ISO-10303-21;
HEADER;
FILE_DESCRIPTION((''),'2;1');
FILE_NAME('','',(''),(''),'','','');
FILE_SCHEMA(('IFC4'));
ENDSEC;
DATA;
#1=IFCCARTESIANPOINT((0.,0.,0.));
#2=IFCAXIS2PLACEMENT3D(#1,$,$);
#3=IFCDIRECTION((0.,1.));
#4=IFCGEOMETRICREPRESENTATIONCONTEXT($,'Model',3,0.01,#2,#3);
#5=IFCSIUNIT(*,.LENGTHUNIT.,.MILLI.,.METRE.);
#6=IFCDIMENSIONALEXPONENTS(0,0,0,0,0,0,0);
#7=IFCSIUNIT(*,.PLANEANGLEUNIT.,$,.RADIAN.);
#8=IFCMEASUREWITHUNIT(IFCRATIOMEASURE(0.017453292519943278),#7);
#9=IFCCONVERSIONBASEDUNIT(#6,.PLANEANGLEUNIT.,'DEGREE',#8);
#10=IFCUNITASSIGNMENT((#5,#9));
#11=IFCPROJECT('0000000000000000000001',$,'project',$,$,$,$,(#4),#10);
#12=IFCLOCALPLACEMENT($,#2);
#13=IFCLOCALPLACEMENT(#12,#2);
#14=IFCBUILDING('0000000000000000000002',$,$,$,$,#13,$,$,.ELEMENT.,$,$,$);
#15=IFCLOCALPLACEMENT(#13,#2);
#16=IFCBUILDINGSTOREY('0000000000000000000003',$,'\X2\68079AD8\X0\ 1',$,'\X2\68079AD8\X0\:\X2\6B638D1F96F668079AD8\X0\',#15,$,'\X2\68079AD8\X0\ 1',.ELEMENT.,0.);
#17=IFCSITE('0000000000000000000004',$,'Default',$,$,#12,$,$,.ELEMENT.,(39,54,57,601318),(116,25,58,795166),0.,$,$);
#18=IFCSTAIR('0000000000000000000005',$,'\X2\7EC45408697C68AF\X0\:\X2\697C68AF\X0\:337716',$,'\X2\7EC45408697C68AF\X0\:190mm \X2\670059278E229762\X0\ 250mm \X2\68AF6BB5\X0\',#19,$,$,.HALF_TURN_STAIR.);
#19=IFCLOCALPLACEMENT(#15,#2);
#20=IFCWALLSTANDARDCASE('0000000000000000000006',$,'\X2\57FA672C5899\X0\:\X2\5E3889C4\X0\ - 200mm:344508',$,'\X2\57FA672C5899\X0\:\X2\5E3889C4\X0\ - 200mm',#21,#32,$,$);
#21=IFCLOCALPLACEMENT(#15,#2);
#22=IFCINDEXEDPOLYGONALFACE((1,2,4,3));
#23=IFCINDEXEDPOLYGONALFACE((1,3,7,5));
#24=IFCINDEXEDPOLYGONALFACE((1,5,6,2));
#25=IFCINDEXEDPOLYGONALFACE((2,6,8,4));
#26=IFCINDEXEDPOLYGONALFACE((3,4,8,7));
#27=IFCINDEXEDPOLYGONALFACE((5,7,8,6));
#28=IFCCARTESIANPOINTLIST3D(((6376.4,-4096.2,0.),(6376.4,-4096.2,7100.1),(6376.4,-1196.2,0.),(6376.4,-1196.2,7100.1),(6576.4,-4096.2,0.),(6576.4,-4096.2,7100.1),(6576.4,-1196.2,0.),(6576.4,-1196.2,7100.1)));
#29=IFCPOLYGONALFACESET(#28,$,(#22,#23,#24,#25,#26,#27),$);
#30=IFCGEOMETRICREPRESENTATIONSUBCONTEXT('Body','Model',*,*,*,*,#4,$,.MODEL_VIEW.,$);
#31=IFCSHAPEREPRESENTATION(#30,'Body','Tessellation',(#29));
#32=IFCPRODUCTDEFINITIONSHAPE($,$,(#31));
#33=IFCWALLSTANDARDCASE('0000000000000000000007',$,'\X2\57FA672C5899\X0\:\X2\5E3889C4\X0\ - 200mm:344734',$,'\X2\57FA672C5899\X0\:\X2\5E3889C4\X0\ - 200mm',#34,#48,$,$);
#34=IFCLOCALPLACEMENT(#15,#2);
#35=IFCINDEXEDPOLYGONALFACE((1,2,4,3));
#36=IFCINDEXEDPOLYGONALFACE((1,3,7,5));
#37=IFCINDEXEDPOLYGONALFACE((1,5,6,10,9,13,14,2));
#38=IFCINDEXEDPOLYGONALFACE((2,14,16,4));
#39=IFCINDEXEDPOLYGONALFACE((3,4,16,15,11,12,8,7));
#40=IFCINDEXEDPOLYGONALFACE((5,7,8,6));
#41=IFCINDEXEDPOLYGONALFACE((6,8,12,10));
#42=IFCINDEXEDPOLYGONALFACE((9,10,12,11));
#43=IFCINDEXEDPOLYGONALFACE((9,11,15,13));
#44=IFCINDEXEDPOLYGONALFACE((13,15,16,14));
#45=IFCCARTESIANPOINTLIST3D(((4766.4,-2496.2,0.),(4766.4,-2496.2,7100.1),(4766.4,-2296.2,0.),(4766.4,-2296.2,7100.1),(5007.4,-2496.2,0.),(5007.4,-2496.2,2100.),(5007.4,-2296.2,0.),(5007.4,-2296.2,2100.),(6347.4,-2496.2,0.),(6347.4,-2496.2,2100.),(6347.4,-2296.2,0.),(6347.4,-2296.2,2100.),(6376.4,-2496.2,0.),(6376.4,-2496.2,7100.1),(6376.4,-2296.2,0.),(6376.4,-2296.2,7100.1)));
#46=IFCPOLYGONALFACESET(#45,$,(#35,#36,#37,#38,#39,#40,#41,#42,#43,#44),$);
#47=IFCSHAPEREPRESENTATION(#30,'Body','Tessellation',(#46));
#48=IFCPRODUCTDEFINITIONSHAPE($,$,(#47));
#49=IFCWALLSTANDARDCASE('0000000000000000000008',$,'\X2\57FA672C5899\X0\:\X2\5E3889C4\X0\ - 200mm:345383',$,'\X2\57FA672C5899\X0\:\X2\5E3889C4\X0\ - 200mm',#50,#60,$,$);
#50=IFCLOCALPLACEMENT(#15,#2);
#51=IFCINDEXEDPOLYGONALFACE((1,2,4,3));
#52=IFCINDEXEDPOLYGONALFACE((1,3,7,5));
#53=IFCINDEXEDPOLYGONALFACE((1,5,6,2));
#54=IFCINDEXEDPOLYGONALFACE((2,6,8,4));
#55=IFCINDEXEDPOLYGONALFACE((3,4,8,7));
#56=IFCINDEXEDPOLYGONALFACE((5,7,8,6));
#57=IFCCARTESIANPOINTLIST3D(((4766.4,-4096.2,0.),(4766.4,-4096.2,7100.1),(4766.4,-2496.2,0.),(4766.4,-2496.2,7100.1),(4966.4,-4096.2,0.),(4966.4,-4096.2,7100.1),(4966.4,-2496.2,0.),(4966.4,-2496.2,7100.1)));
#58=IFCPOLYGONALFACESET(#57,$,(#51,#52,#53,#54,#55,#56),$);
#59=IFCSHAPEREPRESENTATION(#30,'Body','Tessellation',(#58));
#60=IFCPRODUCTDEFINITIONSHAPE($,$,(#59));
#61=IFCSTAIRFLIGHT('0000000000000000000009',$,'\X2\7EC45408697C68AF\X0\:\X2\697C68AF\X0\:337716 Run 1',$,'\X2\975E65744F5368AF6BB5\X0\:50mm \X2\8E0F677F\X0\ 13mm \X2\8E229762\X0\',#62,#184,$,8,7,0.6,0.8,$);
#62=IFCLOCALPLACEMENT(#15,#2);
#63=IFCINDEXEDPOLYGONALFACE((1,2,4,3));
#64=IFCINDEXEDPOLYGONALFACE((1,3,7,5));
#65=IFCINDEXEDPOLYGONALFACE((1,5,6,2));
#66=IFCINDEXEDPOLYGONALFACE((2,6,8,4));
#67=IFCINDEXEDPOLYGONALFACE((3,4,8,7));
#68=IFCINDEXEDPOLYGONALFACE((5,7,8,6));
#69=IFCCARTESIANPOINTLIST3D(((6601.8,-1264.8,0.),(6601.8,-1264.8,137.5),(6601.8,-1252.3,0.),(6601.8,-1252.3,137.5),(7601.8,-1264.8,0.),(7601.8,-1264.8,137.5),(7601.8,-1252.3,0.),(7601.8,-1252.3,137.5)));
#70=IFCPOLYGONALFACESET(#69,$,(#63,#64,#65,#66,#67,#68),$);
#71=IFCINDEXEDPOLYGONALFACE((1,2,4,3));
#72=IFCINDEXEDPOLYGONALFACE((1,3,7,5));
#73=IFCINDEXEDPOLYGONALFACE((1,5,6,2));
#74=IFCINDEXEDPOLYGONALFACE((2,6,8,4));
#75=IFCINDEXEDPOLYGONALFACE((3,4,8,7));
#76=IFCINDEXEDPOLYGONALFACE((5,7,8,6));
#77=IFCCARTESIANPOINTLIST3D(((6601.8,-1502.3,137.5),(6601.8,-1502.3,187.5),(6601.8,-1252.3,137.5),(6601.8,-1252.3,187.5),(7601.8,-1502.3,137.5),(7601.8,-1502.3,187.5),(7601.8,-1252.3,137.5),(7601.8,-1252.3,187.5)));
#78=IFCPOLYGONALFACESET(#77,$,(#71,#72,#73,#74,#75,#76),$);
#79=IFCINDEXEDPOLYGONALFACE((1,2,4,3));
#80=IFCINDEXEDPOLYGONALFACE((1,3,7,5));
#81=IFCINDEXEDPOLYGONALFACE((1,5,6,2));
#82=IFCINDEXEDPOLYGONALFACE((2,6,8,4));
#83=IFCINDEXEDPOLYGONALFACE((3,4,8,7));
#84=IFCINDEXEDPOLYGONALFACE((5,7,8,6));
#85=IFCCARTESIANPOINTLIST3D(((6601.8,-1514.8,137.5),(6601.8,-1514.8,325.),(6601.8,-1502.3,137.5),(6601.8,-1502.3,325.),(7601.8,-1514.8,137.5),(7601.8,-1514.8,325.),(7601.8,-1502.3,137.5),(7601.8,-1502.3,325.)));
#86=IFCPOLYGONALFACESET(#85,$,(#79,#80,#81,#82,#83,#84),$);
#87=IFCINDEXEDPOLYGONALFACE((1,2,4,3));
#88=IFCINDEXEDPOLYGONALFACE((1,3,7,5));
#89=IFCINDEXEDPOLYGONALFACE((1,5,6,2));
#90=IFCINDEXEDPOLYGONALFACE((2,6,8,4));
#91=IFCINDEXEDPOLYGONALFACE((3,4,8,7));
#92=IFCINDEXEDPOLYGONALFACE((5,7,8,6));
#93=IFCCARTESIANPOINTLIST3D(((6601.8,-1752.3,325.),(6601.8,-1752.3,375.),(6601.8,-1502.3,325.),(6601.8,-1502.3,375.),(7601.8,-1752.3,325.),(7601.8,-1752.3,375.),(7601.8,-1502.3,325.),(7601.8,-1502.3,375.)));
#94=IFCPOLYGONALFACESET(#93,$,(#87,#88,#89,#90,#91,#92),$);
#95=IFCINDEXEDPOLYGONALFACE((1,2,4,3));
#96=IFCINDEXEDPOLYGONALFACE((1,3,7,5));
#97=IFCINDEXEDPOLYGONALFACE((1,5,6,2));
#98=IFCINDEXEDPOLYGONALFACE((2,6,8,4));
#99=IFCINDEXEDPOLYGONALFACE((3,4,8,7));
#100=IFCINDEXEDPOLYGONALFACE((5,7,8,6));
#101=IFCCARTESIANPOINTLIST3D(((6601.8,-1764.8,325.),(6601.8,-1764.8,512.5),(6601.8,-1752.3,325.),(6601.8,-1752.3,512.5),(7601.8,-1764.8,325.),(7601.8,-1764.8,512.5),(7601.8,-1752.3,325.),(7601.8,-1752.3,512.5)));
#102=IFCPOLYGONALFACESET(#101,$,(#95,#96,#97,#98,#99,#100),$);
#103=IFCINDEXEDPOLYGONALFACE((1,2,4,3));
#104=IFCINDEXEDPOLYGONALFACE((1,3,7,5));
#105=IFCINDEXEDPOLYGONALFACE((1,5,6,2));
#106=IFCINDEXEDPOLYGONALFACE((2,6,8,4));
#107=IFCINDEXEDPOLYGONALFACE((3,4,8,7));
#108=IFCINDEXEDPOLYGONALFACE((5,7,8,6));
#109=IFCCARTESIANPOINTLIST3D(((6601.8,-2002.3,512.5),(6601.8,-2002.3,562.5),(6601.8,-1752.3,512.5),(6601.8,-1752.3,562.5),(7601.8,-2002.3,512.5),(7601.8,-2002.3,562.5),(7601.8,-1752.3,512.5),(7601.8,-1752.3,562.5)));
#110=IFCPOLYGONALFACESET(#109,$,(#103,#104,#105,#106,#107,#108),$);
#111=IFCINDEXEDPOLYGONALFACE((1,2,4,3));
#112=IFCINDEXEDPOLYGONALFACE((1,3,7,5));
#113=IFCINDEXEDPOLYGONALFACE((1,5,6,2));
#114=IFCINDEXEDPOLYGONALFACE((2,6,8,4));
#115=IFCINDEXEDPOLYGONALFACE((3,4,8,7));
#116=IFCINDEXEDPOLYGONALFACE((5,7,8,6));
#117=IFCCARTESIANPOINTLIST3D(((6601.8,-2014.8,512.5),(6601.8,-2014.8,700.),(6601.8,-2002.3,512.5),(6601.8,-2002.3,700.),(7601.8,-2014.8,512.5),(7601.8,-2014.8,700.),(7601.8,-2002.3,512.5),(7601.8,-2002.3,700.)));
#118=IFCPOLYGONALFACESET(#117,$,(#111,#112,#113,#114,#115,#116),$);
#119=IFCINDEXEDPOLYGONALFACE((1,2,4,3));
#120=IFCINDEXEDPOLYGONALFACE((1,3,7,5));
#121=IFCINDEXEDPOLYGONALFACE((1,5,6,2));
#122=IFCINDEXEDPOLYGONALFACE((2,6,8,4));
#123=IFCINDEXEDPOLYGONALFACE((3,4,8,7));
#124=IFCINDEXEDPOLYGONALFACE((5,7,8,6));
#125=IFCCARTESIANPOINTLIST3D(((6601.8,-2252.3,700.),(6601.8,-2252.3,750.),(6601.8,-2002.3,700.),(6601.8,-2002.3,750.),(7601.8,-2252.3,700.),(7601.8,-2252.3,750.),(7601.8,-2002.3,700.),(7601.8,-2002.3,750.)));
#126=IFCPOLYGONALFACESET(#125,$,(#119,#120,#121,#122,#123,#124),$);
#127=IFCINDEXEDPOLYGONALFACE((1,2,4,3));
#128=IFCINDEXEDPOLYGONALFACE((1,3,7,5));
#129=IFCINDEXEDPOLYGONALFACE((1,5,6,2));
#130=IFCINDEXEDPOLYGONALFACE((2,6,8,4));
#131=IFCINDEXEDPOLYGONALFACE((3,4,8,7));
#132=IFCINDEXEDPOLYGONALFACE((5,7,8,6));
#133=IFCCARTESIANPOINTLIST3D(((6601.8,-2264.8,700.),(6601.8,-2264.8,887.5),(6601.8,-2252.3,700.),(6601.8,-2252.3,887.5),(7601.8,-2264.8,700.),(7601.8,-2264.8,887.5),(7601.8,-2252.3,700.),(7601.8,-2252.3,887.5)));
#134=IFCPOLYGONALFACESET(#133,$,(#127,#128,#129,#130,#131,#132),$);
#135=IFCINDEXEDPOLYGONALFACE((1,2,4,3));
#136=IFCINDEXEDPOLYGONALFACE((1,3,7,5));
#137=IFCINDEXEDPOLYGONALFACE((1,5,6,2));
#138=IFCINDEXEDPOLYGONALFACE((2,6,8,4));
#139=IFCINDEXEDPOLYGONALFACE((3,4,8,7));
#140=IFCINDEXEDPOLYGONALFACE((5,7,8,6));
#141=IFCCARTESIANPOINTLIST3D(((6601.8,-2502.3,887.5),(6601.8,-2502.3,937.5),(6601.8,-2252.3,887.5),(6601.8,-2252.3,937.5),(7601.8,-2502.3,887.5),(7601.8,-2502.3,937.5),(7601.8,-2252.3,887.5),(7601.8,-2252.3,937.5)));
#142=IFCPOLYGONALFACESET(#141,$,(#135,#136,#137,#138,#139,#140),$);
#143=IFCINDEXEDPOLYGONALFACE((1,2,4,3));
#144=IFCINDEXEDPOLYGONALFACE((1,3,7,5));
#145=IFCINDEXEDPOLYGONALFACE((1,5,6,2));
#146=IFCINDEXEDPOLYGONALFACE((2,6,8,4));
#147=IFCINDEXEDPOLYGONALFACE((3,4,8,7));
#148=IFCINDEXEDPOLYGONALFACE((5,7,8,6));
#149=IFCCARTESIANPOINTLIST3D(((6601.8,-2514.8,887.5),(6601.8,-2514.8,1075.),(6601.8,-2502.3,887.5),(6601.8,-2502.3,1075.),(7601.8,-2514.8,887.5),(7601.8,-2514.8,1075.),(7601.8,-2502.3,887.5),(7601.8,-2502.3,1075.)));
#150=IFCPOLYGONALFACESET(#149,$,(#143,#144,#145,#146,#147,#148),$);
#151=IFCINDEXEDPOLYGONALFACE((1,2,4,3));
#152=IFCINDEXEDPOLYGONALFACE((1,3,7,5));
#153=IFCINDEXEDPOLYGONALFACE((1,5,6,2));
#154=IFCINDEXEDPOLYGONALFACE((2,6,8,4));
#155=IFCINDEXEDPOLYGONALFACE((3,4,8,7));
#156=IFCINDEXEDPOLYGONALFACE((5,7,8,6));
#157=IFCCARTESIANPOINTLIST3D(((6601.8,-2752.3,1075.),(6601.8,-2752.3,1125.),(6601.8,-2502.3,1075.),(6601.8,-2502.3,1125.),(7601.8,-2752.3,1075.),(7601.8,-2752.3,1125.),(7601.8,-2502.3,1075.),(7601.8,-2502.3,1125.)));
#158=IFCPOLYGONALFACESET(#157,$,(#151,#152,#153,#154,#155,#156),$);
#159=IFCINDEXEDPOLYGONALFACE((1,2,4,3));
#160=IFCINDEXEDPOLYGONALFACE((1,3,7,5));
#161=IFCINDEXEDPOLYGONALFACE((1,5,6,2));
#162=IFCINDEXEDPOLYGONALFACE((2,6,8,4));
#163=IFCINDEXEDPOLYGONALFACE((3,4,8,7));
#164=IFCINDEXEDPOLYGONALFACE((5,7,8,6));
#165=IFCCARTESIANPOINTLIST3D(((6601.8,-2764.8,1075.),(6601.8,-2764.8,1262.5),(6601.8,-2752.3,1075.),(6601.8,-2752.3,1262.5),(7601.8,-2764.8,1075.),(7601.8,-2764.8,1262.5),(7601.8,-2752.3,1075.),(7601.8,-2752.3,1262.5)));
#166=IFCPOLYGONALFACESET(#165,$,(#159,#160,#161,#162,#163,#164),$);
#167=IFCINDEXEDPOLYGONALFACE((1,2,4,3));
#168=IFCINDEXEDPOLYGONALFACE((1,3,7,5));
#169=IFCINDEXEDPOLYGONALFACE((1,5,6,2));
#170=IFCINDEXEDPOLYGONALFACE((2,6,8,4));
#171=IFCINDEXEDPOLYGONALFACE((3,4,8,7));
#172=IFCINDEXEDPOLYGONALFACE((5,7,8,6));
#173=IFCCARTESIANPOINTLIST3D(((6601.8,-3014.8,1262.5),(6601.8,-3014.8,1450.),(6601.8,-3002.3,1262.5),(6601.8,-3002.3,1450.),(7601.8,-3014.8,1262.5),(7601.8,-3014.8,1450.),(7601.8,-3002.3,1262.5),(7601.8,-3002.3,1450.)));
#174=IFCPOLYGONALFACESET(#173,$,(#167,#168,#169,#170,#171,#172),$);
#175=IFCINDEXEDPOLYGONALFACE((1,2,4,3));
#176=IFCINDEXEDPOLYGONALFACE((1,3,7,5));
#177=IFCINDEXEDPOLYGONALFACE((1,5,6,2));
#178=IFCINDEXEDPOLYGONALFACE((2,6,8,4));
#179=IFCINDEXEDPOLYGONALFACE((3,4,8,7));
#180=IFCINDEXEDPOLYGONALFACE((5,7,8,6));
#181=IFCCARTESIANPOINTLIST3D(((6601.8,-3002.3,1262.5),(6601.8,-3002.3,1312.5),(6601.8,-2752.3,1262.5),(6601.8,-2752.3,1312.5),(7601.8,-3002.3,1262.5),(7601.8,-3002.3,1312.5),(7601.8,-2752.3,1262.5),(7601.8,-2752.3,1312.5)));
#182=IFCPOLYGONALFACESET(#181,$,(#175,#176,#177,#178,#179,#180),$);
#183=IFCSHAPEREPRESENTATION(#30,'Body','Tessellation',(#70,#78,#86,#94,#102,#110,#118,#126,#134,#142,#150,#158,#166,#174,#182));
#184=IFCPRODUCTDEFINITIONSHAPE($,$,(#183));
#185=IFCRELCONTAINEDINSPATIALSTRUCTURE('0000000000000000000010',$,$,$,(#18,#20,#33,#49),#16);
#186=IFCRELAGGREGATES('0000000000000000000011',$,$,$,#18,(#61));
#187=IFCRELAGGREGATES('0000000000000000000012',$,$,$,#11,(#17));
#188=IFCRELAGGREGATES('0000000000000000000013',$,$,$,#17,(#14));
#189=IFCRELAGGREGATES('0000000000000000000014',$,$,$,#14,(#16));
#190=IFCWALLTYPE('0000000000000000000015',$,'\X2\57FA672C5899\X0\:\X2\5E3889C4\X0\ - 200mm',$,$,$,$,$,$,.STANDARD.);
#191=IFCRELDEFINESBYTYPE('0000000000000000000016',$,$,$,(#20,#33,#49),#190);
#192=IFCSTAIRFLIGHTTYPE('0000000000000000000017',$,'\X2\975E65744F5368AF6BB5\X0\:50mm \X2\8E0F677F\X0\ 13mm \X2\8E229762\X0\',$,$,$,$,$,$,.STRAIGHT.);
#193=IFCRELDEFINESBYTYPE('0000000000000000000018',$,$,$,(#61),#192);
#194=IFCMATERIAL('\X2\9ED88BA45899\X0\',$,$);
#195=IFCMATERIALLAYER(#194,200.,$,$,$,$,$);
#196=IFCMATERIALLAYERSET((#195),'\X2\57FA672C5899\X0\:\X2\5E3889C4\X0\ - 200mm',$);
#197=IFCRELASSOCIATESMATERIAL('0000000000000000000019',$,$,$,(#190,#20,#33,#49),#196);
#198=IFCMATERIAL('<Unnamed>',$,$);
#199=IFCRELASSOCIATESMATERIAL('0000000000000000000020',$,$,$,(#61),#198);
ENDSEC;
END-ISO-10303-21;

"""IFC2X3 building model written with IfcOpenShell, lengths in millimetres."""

from ifc_helpers import new_model, entity, si_unit, converted_unit, direction, frame, frame_2d, origin, origin_2d_with_axis, place, context, subcontext, project, spatial, rectangle, extrude, material, layer, layer_set, layer_usage, type_object, element, aggregate, save


model = new_model("IFC2X3")

# Units and contexts
model_context = context("Model", 3, precision=0.01, world=origin(), true_north=direction((0.0, 1.0)))
body_context = subcontext(model_context, "Body", "Model", "MODEL_VIEW")
ifc_project = project(units=[si_unit("LENGTHUNIT", "METRE", prefix="MILLI"), converted_unit("PLANEANGLEUNIT", "DEGREE", entity("IfcRatioMeasure", 0.017453292519943278), si_unit("PLANEANGLEUNIT", "RADIAN"), dimensions=[0, 0, 0, 0, 0, 0, 0])], contexts=[model_context])

# Site, building, storey
site_placement = place(None, origin())
site = spatial("IfcSite", under=ifc_project, at=site_placement, Name="Default", CompositionType="ELEMENT", RefLatitude=(39, 54, 57, 601318), RefLongitude=(116, 25, 58, 795166), RefElevation=0.0)
building_placement = place(site_placement, origin())
building = spatial("IfcBuilding", under=site, at=building_placement, CompositionType="ELEMENT")
storey_placement = place(building_placement, origin())
storey = spatial("IfcBuildingStorey", under=building, at=storey_placement, Name="标高 1", ObjectType="标高:正负零标高", LongName="标高 1", CompositionType="ELEMENT", Elevation=0.0)

# Stair
stair_placement = place(storey_placement, origin())
stair = element("IfcStair", 1, at=stair_placement, inside=storey, Name="组合楼梯:楼梯:337716", ObjectType="组合楼梯:190mm 最大踢面 250mm 梯段", ShapeType="HALF_TURN_STAIR")
ifc_material_1 = material(Name="<Unnamed>")

# Wall
ifc_material_2 = material(Name="默认墙")
ifc_layer_1 = layer(ifc_material_2, 200.0)
ifc_layer_set_1 = layer_set([ifc_layer_1], Name="基本墙:常规 - 200mm")
ifc_layer_usage_1 = layer_usage(ifc_layer_set_1, "AXIS2", "NEGATIVE", 100.0)
wall_type = type_object("IfcWallType", Name="基本墙:常规 - 200mm", PredefinedType="STANDARD", material=ifc_layer_set_1)
wall_1_placement = place(storey_placement, frame((6476.4, -4096.2, 0.0), z_axis=(0.0, 0.0, 1.0), x_axis=(0.0, 1.0, 0.0)))
element("IfcWallStandardCase", 2, at=wall_1_placement, inside=storey, type_object=wall_type, material=ifc_layer_usage_1, Name="基本墙:常规 - 200mm:344508", ObjectType="基本墙:常规 - 200mm", context=body_context, shape_type="SweptSolid", body=[
    extrude(rectangle(XDim=2900.0, YDim=200.0, at=frame_2d((1450.0, 0.0), x_axis=(-1.0, 0.0))), origin(), (0.0, 0.0, 1.0), 7100.1),
])

# Wall, opening
wall_2_placement = place(storey_placement, frame((6376.4, -2396.2, 0.0), z_axis=(0.0, 0.0, 1.0), x_axis=(-1.0, 0.0, 0.0)))
wall_2 = element("IfcWallStandardCase", 3, at=wall_2_placement, inside=storey, type_object=wall_type, material=ifc_layer_usage_1, Name="基本墙:常规 - 200mm:344734", ObjectType="基本墙:常规 - 200mm", context=body_context, shape_type="SweptSolid", body=[
    extrude(rectangle(XDim=1610.0, YDim=200.0, at=frame_2d((805.0, 0.0), x_axis=(-1.0, 0.0))), origin(), (0.0, 0.0, 1.0), 7100.1),
])
opening_placement = place(wall_2_placement, origin())
element("IfcOpeningElement", 4, at=opening_placement, cuts=wall_2, ObjectType="Opening", context=body_context, shape_type="SweptSolid", body=[
    extrude(rectangle(XDim=2100.0, YDim=1340.0, at=frame_2d((0.0, 0.0), x_axis=(1.0, 0.0))), frame((699.0, -1624.0, 1050.0), z_axis=(0.0, 1.0, 0.0), x_axis=(0.0, 0.0, -1.0)), (0.0, 0.0, 1.0), 3048.0),
])

# Wall
wall_3_placement = place(storey_placement, frame((4866.4, -2496.2, 0.0), z_axis=(0.0, 0.0, 1.0), x_axis=(0.0, -1.0, 0.0)))
element("IfcWallStandardCase", 5, at=wall_3_placement, inside=storey, type_object=wall_type, material=ifc_layer_usage_1, Name="基本墙:常规 - 200mm:345383", ObjectType="基本墙:常规 - 200mm", context=body_context, shape_type="SweptSolid", body=[
    extrude(rectangle(XDim=1600.0, YDim=200.0, at=frame_2d((800.0, 0.0), x_axis=(-1.0, 0.0))), origin(), (0.0, 0.0, 1.0), 7100.1),
])

# Stair flight
stair_flight_type = type_object("IfcStairFlightType", Name="非整体梯段:50mm 踏板 13mm 踢面", PredefinedType="STRAIGHT")
stair_flight_1_placement = place(stair_placement, origin())
stair_flight_1 = element("IfcStairFlight", 6, at=stair_flight_1_placement, type_object=stair_flight_type, material=ifc_material_1, Name="组合楼梯:楼梯:337716 Run 1", ObjectType="非整体梯段:50mm 踏板 13mm 踢面", NumberOfRiser=8, NumberOfTreads=7, RiserHeight=0.6, TreadLength=0.8, context=body_context, shape_type="SweptSolid", body=[
    extrude(rectangle(XDim=1000.0, YDim=12.5, at=origin_2d_with_axis()), frame((7101.8, -1258.5, 0.0)), (0.0, 0.0, 1.0), 137.5),
    extrude(rectangle(XDim=250.0, YDim=1000.0, at=origin_2d_with_axis()), frame((7101.8, -1377.3, 137.5), z_axis=(0.0, 0.0, 1.0), x_axis=(0.0, 1.0, 0.0)), (0.0, 0.0, 1.0), 50.0),
    extrude(rectangle(XDim=1000.0, YDim=12.5, at=origin_2d_with_axis()), frame((7101.8, -1508.5, 137.5)), (0.0, 0.0, 1.0), 187.5),
    extrude(rectangle(XDim=250.0, YDim=1000.0, at=frame_2d((0.0, 0.0), x_axis=(1.0, 0.0))), frame((7101.8, -1627.3, 325.0), z_axis=(0.0, 0.0, 1.0), x_axis=(0.0, 1.0, 0.0)), (0.0, 0.0, 1.0), 50.0),
    extrude(rectangle(XDim=1000.0, YDim=12.5, at=frame_2d((0.0, 0.0), x_axis=(1.0, 0.0))), frame((7101.8, -1758.5, 325.0)), (0.0, 0.0, 1.0), 187.5),
    extrude(rectangle(XDim=250.0, YDim=1000.0, at=frame_2d((0.0, 0.0), x_axis=(1.0, 0.0))), frame((7101.8, -1877.3, 512.5), z_axis=(0.0, 0.0, 1.0), x_axis=(0.0, 1.0, 0.0)), (0.0, 0.0, 1.0), 50.0),
    extrude(rectangle(XDim=1000.0, YDim=12.5, at=frame_2d((0.0, 0.0), x_axis=(1.0, 0.0))), frame((7101.8, -2008.5, 512.5)), (0.0, 0.0, 1.0), 187.5),
    extrude(rectangle(XDim=250.0, YDim=1000.0, at=frame_2d((0.0, 0.0), x_axis=(1.0, 0.0))), frame((7101.8, -2127.3, 700.0), z_axis=(0.0, 0.0, 1.0), x_axis=(0.0, 1.0, 0.0)), (0.0, 0.0, 1.0), 50.0),
    extrude(rectangle(XDim=1000.0, YDim=12.5, at=frame_2d((0.0, 0.0), x_axis=(1.0, 0.0))), frame((7101.8, -2258.5, 700.0)), (0.0, 0.0, 1.0), 187.5),
    extrude(rectangle(XDim=250.0, YDim=1000.0, at=frame_2d((0.0, 0.0), x_axis=(1.0, 0.0))), frame((7101.8, -2377.3, 887.5), z_axis=(0.0, 0.0, 1.0), x_axis=(0.0, 1.0, 0.0)), (0.0, 0.0, 1.0), 50.0),
    extrude(rectangle(XDim=1000.0, YDim=12.5, at=frame_2d((0.0, 0.0), x_axis=(1.0, 0.0))), frame((7101.8, -2508.5, 887.5)), (0.0, 0.0, 1.0), 187.5),
    extrude(rectangle(XDim=250.0, YDim=1000.0, at=frame_2d((0.0, 0.0), x_axis=(1.0, 0.0))), frame((7101.8, -2627.3, 1075.0), z_axis=(0.0, 0.0, 1.0), x_axis=(0.0, 1.0, 0.0)), (0.0, 0.0, 1.0), 50.0),
    extrude(rectangle(XDim=1000.0, YDim=12.5, at=frame_2d((0.0, 0.0), x_axis=(1.0, 0.0))), frame((7101.8, -2758.5, 1075.0)), (0.0, 0.0, 1.0), 187.5),
    extrude(rectangle(XDim=1000.0, YDim=12.5, at=frame_2d((0.0, 0.0), x_axis=(1.0, 0.0))), frame((7101.8, -3008.5, 1262.5)), (0.0, 0.0, 1.0), 187.5),
    extrude(rectangle(XDim=250.0, YDim=1000.0, at=frame_2d((0.0, 0.0), x_axis=(1.0, 0.0))), frame((7101.8, -2877.3, 1262.5), z_axis=(0.0, 0.0, 1.0), x_axis=(0.0, 1.0, 0.0)), (0.0, 0.0, 1.0), 50.0),
])
aggregate(stair, [stair_flight_1])

save(model, "model.ifc")
